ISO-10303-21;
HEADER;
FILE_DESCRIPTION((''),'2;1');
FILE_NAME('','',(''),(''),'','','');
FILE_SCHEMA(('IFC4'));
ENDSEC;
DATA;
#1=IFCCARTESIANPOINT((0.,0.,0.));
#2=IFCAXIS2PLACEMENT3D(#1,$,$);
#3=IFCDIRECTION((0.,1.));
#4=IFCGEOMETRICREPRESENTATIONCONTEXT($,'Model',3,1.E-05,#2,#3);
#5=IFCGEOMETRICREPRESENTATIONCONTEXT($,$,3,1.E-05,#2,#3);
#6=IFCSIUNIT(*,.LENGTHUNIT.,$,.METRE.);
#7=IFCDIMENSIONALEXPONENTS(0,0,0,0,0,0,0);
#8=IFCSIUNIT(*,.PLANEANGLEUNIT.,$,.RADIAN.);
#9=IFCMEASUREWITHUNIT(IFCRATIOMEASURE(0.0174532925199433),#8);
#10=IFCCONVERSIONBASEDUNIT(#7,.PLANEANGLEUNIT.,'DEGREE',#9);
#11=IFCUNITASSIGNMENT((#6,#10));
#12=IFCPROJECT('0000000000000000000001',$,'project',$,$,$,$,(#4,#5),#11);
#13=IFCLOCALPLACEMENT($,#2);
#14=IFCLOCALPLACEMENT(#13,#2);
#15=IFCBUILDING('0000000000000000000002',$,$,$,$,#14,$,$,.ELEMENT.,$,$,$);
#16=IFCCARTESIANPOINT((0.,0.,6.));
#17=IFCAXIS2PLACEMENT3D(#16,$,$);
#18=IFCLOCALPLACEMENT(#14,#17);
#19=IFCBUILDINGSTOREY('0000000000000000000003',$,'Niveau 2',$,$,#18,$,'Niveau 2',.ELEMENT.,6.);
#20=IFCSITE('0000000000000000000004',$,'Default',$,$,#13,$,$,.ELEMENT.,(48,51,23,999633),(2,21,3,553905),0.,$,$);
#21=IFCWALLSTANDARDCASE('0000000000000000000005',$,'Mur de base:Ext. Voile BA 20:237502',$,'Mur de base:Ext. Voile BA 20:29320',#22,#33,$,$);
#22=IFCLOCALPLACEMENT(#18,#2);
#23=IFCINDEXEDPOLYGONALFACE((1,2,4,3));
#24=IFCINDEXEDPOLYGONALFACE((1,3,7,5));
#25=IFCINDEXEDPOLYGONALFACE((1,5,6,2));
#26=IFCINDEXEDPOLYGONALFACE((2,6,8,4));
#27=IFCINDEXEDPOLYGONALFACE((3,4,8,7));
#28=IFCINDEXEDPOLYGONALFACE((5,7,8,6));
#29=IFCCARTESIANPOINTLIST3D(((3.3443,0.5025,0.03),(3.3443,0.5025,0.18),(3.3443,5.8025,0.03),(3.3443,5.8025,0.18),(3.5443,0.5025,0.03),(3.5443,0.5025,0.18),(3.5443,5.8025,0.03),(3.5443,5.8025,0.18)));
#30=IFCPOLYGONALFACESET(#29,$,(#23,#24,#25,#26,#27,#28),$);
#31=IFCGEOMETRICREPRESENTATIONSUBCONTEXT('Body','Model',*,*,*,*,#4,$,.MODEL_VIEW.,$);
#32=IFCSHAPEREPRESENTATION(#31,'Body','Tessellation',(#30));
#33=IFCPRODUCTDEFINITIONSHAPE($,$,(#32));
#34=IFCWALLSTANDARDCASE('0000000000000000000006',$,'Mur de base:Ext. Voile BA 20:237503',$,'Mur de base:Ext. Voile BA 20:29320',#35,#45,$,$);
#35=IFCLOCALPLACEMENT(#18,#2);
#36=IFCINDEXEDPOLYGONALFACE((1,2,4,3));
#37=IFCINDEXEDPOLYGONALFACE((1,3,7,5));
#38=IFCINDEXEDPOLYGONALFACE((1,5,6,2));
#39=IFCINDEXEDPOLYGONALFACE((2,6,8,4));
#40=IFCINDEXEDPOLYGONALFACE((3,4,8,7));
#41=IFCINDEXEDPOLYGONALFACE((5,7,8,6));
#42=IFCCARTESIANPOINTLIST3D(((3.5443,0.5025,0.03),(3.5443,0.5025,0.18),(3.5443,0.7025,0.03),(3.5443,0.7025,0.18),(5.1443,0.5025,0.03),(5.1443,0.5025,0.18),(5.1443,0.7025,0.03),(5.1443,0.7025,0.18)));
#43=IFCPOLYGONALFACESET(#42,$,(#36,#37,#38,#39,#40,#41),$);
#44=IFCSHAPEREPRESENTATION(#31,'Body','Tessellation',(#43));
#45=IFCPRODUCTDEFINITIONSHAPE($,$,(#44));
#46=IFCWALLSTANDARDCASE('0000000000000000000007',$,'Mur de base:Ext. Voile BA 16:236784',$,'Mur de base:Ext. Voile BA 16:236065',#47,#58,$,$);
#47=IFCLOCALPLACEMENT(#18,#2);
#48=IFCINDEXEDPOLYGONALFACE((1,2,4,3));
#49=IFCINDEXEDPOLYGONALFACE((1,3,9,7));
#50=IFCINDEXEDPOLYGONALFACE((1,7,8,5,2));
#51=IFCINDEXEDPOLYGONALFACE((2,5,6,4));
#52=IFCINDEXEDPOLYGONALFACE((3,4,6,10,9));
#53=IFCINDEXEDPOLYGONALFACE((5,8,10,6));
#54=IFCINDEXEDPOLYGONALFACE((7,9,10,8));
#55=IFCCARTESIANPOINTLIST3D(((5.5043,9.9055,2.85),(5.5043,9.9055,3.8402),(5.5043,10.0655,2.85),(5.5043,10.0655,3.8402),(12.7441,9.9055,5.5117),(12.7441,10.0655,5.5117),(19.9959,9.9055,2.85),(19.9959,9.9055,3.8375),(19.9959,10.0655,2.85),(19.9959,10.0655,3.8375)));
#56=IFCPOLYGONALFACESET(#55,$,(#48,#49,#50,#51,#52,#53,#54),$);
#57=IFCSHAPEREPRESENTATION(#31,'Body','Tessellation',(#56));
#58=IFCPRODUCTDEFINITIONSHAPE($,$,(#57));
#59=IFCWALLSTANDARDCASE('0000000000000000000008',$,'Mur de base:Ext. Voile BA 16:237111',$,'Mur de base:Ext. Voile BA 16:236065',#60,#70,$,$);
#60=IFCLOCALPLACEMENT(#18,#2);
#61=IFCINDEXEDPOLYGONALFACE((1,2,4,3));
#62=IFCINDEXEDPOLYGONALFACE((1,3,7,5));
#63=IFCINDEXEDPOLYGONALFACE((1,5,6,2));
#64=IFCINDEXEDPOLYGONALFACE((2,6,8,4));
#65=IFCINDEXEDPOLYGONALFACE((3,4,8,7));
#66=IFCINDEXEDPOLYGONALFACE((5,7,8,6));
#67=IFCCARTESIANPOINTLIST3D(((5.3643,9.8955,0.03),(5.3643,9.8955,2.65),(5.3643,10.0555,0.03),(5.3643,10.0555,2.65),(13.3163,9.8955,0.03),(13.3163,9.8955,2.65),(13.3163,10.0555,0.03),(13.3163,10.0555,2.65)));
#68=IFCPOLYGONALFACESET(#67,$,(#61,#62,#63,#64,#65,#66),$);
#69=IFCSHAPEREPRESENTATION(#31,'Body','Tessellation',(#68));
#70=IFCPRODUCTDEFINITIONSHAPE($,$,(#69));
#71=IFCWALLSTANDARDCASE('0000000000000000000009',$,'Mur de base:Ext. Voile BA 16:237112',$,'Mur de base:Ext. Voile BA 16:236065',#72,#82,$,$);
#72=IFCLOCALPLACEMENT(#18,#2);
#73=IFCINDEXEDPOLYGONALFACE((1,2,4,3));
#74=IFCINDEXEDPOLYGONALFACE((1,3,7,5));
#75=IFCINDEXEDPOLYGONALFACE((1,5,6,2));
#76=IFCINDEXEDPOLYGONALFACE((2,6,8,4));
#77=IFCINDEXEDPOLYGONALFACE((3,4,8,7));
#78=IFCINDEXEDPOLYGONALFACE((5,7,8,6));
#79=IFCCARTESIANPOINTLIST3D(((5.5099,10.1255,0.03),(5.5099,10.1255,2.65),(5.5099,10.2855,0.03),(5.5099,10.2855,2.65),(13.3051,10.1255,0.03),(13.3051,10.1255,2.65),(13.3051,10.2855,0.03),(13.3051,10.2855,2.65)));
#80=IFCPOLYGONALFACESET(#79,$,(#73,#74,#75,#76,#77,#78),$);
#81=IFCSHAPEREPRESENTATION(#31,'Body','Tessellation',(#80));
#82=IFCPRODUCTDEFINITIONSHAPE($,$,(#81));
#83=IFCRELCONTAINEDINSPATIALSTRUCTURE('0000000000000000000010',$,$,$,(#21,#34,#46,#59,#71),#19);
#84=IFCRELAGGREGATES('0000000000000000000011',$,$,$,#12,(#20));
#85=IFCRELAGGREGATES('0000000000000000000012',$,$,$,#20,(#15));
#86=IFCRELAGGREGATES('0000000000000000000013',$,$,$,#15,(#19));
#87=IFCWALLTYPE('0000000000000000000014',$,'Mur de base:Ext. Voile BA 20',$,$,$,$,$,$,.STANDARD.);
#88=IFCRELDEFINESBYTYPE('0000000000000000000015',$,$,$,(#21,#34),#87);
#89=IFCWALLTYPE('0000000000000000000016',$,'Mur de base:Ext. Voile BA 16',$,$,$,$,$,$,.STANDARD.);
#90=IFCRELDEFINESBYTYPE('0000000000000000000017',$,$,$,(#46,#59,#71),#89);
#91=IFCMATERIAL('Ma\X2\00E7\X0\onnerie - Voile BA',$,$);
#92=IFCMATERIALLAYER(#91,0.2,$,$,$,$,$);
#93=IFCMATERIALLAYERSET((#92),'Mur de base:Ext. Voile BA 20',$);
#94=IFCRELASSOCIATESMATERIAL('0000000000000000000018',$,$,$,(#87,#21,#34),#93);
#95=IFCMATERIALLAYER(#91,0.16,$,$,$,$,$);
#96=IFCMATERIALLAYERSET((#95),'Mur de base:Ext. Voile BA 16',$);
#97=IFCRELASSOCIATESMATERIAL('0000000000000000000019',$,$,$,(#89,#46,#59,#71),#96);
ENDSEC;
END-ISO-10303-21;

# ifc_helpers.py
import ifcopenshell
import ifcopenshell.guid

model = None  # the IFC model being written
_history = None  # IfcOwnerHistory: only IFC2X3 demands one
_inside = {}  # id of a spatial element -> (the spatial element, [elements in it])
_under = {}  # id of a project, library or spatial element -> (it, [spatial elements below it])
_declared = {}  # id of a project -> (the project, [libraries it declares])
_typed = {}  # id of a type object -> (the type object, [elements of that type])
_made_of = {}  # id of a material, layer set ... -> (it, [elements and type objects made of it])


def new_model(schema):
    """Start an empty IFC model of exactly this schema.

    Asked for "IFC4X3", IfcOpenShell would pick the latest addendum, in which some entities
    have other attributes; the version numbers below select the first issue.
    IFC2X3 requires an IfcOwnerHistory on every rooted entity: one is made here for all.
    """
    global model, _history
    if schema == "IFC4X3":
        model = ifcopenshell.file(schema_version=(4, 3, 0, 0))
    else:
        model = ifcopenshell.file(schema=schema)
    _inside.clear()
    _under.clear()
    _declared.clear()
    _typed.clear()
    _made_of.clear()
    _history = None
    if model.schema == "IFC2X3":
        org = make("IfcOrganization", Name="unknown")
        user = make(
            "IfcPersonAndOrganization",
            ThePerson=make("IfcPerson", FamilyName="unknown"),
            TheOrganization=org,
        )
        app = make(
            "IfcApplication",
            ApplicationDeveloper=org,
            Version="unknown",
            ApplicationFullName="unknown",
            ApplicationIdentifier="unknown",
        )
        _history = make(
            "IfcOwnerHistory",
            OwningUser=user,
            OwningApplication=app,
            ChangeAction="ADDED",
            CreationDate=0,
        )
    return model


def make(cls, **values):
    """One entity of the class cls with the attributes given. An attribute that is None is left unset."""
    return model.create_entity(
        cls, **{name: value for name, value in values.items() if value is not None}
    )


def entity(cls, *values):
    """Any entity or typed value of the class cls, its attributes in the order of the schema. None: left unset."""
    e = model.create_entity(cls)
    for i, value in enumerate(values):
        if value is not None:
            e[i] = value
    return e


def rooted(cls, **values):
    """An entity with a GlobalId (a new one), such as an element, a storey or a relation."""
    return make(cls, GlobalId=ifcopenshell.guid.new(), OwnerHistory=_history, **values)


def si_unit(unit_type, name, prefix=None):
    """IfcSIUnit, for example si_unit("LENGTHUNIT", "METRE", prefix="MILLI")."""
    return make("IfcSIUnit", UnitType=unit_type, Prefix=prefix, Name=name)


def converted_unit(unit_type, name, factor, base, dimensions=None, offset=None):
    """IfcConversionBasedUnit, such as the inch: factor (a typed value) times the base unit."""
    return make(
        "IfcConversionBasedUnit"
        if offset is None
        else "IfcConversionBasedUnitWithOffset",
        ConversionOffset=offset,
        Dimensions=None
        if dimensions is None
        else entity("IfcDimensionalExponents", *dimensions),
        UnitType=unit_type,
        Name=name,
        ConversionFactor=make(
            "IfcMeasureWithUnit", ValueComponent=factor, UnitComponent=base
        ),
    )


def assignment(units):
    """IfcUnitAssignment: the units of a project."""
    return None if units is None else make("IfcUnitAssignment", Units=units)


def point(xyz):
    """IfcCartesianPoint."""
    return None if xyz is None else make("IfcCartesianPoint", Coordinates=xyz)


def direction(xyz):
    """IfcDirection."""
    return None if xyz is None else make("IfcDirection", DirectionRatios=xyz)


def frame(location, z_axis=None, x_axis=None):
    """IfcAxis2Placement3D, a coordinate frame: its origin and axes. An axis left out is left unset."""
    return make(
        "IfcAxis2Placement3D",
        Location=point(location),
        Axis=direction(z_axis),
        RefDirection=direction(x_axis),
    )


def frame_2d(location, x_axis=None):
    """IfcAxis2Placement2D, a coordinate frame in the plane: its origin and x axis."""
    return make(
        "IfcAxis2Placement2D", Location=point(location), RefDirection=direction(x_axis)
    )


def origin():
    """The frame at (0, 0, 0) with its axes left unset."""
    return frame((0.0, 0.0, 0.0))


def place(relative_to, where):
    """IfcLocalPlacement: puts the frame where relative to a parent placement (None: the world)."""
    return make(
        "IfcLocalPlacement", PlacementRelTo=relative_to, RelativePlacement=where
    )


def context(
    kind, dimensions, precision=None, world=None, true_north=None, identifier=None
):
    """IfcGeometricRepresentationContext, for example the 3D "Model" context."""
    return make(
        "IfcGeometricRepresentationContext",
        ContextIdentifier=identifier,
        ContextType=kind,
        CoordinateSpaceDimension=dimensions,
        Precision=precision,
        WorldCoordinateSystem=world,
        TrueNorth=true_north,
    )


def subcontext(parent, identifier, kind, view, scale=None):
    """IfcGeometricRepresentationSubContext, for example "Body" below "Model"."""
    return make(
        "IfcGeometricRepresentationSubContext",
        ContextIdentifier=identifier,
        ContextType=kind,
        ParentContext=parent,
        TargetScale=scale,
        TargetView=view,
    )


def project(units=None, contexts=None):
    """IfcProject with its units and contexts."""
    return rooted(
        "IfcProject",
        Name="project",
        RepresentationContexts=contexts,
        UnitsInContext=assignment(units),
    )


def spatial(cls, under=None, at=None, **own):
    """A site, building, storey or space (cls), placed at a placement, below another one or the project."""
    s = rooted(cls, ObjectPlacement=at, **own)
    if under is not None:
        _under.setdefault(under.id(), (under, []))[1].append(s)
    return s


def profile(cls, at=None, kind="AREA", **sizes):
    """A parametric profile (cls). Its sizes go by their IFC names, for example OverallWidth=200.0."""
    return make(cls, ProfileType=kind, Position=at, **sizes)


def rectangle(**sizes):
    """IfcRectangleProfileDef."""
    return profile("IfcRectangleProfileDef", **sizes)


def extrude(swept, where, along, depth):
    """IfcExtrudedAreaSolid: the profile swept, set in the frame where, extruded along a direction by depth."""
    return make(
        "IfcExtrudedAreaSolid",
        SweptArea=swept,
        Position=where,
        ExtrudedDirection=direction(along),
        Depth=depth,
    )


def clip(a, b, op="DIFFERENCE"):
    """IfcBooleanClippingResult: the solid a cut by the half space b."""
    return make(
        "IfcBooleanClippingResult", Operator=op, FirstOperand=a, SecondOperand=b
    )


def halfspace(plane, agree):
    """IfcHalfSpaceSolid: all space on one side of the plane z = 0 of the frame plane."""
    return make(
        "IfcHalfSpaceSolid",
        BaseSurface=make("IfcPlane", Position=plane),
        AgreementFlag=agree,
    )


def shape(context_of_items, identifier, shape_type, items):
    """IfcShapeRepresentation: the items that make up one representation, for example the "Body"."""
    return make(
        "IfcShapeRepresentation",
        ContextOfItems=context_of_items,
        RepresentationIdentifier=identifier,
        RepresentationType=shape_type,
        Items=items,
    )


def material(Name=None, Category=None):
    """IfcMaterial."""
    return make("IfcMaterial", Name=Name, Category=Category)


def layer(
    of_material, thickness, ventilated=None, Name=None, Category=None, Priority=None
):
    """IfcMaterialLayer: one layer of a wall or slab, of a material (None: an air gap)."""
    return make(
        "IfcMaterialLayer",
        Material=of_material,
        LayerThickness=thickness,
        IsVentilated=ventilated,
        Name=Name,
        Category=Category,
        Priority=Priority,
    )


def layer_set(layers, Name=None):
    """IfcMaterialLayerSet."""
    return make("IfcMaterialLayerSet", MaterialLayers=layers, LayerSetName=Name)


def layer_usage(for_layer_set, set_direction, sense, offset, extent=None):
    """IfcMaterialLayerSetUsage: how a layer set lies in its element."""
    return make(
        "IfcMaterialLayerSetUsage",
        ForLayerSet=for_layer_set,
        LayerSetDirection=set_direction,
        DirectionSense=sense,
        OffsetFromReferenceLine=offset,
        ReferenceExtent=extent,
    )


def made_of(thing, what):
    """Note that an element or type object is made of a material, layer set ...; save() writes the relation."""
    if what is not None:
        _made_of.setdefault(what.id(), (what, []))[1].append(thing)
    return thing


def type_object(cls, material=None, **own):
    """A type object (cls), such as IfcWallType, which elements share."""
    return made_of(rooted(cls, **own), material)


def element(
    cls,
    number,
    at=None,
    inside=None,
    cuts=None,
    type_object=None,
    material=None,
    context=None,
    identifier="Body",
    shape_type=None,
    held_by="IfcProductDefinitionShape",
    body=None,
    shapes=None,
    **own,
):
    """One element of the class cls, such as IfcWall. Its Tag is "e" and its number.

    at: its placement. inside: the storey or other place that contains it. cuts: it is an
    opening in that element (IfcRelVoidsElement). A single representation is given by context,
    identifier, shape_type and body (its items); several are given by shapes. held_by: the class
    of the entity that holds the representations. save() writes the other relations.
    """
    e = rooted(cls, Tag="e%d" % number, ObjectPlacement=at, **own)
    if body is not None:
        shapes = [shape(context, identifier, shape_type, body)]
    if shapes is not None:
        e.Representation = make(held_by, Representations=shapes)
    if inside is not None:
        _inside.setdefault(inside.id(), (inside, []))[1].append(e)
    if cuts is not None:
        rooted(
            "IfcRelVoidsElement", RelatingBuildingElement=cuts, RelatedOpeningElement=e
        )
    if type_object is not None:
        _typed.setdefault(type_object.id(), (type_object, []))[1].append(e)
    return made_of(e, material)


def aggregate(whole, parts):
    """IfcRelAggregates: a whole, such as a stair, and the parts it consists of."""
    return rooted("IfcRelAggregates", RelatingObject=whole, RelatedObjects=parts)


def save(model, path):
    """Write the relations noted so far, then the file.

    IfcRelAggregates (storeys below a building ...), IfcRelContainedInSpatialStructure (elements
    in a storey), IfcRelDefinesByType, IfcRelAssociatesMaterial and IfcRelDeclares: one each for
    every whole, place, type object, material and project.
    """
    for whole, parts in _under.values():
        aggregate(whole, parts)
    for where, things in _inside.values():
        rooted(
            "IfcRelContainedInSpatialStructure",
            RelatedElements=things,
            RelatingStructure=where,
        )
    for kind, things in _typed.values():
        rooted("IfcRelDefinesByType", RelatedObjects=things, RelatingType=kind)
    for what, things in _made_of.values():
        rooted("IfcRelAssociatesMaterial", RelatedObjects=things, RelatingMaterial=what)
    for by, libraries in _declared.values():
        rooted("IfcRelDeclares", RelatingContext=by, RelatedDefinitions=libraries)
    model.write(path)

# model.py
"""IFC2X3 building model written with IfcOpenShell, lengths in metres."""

from ifc_helpers import new_model, entity, si_unit, converted_unit, direction, frame, frame_2d, origin, place, context, subcontext, project, spatial, rectangle, extrude, clip, halfspace, material, layer, layer_set, layer_usage, type_object, element, save


model = new_model("IFC2X3")

# Units and contexts
model_context = context("Model", 3, precision=1e-05, world=origin(), true_north=direction((0.0, 1.0)))
context_of_model = context(None, 3, precision=1e-05, world=origin(), true_north=direction((0.0, 1.0)))
body_context = subcontext(model_context, "Body", "Model", "MODEL_VIEW")
ifc_project = project(units=[si_unit("LENGTHUNIT", "METRE"), converted_unit("PLANEANGLEUNIT", "DEGREE", entity("IfcRatioMeasure", 0.0174532925199433), si_unit("PLANEANGLEUNIT", "RADIAN"), dimensions=[0, 0, 0, 0, 0, 0, 0])], contexts=[model_context, context_of_model])

# Site, building, storey
site_placement = place(None, origin())
site = spatial("IfcSite", under=ifc_project, at=site_placement, Name="Default", CompositionType="ELEMENT", RefLatitude=(48, 51, 23, 999633), RefLongitude=(2, 21, 3, 553905), RefElevation=0.0)
building_placement = place(site_placement, origin())
building = spatial("IfcBuilding", under=site, at=building_placement, CompositionType="ELEMENT")
storey_placement = place(building_placement, frame((0.0, 0.0, 6.0)))
storey = spatial("IfcBuildingStorey", under=building, at=storey_placement, Name="Niveau 2", LongName="Niveau 2", CompositionType="ELEMENT", Elevation=6.0)

# Shared definitions
ifc_material_1 = material(Name="Maçonnerie - Voile BA")
ifc_layer_1 = layer(ifc_material_1, 0.2)
ifc_layer_set_1 = layer_set([ifc_layer_1], Name="Mur de base:Ext. Voile BA 20")
wall_type_1 = type_object("IfcWallType", Name="Mur de base:Ext. Voile BA 20", PredefinedType="STANDARD", material=ifc_layer_set_1)

# Walls
ifc_layer_usage_1 = layer_usage(ifc_layer_set_1, "AXIS2", "NEGATIVE", 0.1)
wall_1_placement = place(storey_placement, frame((3.4443, 5.8025, 0.03), z_axis=(0.0, 0.0, 1.0), x_axis=(0.0, -1.0, 0.0)))
element("IfcWallStandardCase", 1, at=wall_1_placement, inside=storey, type_object=wall_type_1, material=ifc_layer_usage_1, Name="Mur de base:Ext. Voile BA 20:237502", ObjectType="Mur de base:Ext. Voile BA 20:29320", context=body_context, shape_type="SweptSolid", body=[
    extrude(rectangle(XDim=5.3, YDim=0.2, at=frame_2d((2.65, 0.0), x_axis=(-1.0, 0.0))), origin(), (0.0, 0.0, 1.0), 0.15),
])
ifc_layer_usage_2 = layer_usage(ifc_layer_set_1, "AXIS2", "NEGATIVE", 0.1)
wall_2_placement = place(storey_placement, frame((3.5443, 0.6025, 0.03)))
element("IfcWallStandardCase", 2, at=wall_2_placement, inside=storey, type_object=wall_type_1, material=ifc_layer_usage_2, Name="Mur de base:Ext. Voile BA 20:237503", ObjectType="Mur de base:Ext. Voile BA 20:29320", context=body_context, shape_type="SweptSolid", body=[
    extrude(rectangle(XDim=1.6, YDim=0.2, at=frame_2d((0.8, 0.0), x_axis=(-1.0, 0.0))), origin(), (0.0, 0.0, 1.0), 0.15),
])
ifc_layer_2 = layer(ifc_material_1, 0.16)
ifc_layer_set_2 = layer_set([ifc_layer_2], Name="Mur de base:Ext. Voile BA 16")
ifc_layer_usage_3 = layer_usage(ifc_layer_set_2, "AXIS2", "NEGATIVE", 0.08)
wall_type_2 = type_object("IfcWallType", Name="Mur de base:Ext. Voile BA 16", PredefinedType="STANDARD", material=ifc_layer_set_2)
wall_3_placement = place(storey_placement, frame((5.5043, 9.9855, 2.85)))
element("IfcWallStandardCase", 3, at=wall_3_placement, inside=storey, type_object=wall_type_2, material=ifc_layer_usage_3, Name="Mur de base:Ext. Voile BA 16:236784", ObjectType="Mur de base:Ext. Voile BA 16:236065", context=body_context, shape_type="Clipping", body=[
    clip(clip(extrude(rectangle(XDim=14.4917, YDim=0.16, at=frame_2d((7.2458, 0.0), x_axis=(-1.0, 0.0))), origin(), (0.0, 0.0, 1.0), 2.6617), halfspace(frame((0.0, -0.08, 0.9902), z_axis=(-0.224951, 0.0, 0.97437), x_axis=(0.0, 1.0, 0.0)), False)), halfspace(frame((7.2399, -0.08, 2.6617), z_axis=(0.224951, 0.0, 0.97437), x_axis=(0.0, 1.0, 0.0)), False)),
])

# Walls
ifc_layer_usage_4 = layer_usage(ifc_layer_set_2, "AXIS2", "NEGATIVE", 0.08)
wall_4_placement = place(storey_placement, frame((5.3643, 9.9755, 0.03)))
element("IfcWallStandardCase", 4, at=wall_4_placement, inside=storey, type_object=wall_type_2, material=ifc_layer_usage_4, Name="Mur de base:Ext. Voile BA 16:237111", ObjectType="Mur de base:Ext. Voile BA 16:236065", context=body_context, shape_type="SweptSolid", body=[
    extrude(rectangle(XDim=7.952, YDim=0.16, at=frame_2d((3.976, 0.0), x_axis=(-1.0, 0.0))), origin(), (0.0, 0.0, 1.0), 2.62),
])
ifc_layer_usage_5 = layer_usage(ifc_layer_set_2, "AXIS2", "NEGATIVE", 0.08)
wall_5_placement = place(storey_placement, frame((5.5099, 10.2055, 0.03)))
element("IfcWallStandardCase", 5, at=wall_5_placement, inside=storey, type_object=wall_type_2, material=ifc_layer_usage_5, Name="Mur de base:Ext. Voile BA 16:237112", ObjectType="Mur de base:Ext. Voile BA 16:236065", context=body_context, shape_type="SweptSolid", body=[
    extrude(rectangle(XDim=7.7952, YDim=0.16, at=frame_2d((3.8976, 0.0), x_axis=(-1.0, 0.0))), origin(), (0.0, 0.0, 1.0), 2.62),
])

save(model, "model.ifc")
